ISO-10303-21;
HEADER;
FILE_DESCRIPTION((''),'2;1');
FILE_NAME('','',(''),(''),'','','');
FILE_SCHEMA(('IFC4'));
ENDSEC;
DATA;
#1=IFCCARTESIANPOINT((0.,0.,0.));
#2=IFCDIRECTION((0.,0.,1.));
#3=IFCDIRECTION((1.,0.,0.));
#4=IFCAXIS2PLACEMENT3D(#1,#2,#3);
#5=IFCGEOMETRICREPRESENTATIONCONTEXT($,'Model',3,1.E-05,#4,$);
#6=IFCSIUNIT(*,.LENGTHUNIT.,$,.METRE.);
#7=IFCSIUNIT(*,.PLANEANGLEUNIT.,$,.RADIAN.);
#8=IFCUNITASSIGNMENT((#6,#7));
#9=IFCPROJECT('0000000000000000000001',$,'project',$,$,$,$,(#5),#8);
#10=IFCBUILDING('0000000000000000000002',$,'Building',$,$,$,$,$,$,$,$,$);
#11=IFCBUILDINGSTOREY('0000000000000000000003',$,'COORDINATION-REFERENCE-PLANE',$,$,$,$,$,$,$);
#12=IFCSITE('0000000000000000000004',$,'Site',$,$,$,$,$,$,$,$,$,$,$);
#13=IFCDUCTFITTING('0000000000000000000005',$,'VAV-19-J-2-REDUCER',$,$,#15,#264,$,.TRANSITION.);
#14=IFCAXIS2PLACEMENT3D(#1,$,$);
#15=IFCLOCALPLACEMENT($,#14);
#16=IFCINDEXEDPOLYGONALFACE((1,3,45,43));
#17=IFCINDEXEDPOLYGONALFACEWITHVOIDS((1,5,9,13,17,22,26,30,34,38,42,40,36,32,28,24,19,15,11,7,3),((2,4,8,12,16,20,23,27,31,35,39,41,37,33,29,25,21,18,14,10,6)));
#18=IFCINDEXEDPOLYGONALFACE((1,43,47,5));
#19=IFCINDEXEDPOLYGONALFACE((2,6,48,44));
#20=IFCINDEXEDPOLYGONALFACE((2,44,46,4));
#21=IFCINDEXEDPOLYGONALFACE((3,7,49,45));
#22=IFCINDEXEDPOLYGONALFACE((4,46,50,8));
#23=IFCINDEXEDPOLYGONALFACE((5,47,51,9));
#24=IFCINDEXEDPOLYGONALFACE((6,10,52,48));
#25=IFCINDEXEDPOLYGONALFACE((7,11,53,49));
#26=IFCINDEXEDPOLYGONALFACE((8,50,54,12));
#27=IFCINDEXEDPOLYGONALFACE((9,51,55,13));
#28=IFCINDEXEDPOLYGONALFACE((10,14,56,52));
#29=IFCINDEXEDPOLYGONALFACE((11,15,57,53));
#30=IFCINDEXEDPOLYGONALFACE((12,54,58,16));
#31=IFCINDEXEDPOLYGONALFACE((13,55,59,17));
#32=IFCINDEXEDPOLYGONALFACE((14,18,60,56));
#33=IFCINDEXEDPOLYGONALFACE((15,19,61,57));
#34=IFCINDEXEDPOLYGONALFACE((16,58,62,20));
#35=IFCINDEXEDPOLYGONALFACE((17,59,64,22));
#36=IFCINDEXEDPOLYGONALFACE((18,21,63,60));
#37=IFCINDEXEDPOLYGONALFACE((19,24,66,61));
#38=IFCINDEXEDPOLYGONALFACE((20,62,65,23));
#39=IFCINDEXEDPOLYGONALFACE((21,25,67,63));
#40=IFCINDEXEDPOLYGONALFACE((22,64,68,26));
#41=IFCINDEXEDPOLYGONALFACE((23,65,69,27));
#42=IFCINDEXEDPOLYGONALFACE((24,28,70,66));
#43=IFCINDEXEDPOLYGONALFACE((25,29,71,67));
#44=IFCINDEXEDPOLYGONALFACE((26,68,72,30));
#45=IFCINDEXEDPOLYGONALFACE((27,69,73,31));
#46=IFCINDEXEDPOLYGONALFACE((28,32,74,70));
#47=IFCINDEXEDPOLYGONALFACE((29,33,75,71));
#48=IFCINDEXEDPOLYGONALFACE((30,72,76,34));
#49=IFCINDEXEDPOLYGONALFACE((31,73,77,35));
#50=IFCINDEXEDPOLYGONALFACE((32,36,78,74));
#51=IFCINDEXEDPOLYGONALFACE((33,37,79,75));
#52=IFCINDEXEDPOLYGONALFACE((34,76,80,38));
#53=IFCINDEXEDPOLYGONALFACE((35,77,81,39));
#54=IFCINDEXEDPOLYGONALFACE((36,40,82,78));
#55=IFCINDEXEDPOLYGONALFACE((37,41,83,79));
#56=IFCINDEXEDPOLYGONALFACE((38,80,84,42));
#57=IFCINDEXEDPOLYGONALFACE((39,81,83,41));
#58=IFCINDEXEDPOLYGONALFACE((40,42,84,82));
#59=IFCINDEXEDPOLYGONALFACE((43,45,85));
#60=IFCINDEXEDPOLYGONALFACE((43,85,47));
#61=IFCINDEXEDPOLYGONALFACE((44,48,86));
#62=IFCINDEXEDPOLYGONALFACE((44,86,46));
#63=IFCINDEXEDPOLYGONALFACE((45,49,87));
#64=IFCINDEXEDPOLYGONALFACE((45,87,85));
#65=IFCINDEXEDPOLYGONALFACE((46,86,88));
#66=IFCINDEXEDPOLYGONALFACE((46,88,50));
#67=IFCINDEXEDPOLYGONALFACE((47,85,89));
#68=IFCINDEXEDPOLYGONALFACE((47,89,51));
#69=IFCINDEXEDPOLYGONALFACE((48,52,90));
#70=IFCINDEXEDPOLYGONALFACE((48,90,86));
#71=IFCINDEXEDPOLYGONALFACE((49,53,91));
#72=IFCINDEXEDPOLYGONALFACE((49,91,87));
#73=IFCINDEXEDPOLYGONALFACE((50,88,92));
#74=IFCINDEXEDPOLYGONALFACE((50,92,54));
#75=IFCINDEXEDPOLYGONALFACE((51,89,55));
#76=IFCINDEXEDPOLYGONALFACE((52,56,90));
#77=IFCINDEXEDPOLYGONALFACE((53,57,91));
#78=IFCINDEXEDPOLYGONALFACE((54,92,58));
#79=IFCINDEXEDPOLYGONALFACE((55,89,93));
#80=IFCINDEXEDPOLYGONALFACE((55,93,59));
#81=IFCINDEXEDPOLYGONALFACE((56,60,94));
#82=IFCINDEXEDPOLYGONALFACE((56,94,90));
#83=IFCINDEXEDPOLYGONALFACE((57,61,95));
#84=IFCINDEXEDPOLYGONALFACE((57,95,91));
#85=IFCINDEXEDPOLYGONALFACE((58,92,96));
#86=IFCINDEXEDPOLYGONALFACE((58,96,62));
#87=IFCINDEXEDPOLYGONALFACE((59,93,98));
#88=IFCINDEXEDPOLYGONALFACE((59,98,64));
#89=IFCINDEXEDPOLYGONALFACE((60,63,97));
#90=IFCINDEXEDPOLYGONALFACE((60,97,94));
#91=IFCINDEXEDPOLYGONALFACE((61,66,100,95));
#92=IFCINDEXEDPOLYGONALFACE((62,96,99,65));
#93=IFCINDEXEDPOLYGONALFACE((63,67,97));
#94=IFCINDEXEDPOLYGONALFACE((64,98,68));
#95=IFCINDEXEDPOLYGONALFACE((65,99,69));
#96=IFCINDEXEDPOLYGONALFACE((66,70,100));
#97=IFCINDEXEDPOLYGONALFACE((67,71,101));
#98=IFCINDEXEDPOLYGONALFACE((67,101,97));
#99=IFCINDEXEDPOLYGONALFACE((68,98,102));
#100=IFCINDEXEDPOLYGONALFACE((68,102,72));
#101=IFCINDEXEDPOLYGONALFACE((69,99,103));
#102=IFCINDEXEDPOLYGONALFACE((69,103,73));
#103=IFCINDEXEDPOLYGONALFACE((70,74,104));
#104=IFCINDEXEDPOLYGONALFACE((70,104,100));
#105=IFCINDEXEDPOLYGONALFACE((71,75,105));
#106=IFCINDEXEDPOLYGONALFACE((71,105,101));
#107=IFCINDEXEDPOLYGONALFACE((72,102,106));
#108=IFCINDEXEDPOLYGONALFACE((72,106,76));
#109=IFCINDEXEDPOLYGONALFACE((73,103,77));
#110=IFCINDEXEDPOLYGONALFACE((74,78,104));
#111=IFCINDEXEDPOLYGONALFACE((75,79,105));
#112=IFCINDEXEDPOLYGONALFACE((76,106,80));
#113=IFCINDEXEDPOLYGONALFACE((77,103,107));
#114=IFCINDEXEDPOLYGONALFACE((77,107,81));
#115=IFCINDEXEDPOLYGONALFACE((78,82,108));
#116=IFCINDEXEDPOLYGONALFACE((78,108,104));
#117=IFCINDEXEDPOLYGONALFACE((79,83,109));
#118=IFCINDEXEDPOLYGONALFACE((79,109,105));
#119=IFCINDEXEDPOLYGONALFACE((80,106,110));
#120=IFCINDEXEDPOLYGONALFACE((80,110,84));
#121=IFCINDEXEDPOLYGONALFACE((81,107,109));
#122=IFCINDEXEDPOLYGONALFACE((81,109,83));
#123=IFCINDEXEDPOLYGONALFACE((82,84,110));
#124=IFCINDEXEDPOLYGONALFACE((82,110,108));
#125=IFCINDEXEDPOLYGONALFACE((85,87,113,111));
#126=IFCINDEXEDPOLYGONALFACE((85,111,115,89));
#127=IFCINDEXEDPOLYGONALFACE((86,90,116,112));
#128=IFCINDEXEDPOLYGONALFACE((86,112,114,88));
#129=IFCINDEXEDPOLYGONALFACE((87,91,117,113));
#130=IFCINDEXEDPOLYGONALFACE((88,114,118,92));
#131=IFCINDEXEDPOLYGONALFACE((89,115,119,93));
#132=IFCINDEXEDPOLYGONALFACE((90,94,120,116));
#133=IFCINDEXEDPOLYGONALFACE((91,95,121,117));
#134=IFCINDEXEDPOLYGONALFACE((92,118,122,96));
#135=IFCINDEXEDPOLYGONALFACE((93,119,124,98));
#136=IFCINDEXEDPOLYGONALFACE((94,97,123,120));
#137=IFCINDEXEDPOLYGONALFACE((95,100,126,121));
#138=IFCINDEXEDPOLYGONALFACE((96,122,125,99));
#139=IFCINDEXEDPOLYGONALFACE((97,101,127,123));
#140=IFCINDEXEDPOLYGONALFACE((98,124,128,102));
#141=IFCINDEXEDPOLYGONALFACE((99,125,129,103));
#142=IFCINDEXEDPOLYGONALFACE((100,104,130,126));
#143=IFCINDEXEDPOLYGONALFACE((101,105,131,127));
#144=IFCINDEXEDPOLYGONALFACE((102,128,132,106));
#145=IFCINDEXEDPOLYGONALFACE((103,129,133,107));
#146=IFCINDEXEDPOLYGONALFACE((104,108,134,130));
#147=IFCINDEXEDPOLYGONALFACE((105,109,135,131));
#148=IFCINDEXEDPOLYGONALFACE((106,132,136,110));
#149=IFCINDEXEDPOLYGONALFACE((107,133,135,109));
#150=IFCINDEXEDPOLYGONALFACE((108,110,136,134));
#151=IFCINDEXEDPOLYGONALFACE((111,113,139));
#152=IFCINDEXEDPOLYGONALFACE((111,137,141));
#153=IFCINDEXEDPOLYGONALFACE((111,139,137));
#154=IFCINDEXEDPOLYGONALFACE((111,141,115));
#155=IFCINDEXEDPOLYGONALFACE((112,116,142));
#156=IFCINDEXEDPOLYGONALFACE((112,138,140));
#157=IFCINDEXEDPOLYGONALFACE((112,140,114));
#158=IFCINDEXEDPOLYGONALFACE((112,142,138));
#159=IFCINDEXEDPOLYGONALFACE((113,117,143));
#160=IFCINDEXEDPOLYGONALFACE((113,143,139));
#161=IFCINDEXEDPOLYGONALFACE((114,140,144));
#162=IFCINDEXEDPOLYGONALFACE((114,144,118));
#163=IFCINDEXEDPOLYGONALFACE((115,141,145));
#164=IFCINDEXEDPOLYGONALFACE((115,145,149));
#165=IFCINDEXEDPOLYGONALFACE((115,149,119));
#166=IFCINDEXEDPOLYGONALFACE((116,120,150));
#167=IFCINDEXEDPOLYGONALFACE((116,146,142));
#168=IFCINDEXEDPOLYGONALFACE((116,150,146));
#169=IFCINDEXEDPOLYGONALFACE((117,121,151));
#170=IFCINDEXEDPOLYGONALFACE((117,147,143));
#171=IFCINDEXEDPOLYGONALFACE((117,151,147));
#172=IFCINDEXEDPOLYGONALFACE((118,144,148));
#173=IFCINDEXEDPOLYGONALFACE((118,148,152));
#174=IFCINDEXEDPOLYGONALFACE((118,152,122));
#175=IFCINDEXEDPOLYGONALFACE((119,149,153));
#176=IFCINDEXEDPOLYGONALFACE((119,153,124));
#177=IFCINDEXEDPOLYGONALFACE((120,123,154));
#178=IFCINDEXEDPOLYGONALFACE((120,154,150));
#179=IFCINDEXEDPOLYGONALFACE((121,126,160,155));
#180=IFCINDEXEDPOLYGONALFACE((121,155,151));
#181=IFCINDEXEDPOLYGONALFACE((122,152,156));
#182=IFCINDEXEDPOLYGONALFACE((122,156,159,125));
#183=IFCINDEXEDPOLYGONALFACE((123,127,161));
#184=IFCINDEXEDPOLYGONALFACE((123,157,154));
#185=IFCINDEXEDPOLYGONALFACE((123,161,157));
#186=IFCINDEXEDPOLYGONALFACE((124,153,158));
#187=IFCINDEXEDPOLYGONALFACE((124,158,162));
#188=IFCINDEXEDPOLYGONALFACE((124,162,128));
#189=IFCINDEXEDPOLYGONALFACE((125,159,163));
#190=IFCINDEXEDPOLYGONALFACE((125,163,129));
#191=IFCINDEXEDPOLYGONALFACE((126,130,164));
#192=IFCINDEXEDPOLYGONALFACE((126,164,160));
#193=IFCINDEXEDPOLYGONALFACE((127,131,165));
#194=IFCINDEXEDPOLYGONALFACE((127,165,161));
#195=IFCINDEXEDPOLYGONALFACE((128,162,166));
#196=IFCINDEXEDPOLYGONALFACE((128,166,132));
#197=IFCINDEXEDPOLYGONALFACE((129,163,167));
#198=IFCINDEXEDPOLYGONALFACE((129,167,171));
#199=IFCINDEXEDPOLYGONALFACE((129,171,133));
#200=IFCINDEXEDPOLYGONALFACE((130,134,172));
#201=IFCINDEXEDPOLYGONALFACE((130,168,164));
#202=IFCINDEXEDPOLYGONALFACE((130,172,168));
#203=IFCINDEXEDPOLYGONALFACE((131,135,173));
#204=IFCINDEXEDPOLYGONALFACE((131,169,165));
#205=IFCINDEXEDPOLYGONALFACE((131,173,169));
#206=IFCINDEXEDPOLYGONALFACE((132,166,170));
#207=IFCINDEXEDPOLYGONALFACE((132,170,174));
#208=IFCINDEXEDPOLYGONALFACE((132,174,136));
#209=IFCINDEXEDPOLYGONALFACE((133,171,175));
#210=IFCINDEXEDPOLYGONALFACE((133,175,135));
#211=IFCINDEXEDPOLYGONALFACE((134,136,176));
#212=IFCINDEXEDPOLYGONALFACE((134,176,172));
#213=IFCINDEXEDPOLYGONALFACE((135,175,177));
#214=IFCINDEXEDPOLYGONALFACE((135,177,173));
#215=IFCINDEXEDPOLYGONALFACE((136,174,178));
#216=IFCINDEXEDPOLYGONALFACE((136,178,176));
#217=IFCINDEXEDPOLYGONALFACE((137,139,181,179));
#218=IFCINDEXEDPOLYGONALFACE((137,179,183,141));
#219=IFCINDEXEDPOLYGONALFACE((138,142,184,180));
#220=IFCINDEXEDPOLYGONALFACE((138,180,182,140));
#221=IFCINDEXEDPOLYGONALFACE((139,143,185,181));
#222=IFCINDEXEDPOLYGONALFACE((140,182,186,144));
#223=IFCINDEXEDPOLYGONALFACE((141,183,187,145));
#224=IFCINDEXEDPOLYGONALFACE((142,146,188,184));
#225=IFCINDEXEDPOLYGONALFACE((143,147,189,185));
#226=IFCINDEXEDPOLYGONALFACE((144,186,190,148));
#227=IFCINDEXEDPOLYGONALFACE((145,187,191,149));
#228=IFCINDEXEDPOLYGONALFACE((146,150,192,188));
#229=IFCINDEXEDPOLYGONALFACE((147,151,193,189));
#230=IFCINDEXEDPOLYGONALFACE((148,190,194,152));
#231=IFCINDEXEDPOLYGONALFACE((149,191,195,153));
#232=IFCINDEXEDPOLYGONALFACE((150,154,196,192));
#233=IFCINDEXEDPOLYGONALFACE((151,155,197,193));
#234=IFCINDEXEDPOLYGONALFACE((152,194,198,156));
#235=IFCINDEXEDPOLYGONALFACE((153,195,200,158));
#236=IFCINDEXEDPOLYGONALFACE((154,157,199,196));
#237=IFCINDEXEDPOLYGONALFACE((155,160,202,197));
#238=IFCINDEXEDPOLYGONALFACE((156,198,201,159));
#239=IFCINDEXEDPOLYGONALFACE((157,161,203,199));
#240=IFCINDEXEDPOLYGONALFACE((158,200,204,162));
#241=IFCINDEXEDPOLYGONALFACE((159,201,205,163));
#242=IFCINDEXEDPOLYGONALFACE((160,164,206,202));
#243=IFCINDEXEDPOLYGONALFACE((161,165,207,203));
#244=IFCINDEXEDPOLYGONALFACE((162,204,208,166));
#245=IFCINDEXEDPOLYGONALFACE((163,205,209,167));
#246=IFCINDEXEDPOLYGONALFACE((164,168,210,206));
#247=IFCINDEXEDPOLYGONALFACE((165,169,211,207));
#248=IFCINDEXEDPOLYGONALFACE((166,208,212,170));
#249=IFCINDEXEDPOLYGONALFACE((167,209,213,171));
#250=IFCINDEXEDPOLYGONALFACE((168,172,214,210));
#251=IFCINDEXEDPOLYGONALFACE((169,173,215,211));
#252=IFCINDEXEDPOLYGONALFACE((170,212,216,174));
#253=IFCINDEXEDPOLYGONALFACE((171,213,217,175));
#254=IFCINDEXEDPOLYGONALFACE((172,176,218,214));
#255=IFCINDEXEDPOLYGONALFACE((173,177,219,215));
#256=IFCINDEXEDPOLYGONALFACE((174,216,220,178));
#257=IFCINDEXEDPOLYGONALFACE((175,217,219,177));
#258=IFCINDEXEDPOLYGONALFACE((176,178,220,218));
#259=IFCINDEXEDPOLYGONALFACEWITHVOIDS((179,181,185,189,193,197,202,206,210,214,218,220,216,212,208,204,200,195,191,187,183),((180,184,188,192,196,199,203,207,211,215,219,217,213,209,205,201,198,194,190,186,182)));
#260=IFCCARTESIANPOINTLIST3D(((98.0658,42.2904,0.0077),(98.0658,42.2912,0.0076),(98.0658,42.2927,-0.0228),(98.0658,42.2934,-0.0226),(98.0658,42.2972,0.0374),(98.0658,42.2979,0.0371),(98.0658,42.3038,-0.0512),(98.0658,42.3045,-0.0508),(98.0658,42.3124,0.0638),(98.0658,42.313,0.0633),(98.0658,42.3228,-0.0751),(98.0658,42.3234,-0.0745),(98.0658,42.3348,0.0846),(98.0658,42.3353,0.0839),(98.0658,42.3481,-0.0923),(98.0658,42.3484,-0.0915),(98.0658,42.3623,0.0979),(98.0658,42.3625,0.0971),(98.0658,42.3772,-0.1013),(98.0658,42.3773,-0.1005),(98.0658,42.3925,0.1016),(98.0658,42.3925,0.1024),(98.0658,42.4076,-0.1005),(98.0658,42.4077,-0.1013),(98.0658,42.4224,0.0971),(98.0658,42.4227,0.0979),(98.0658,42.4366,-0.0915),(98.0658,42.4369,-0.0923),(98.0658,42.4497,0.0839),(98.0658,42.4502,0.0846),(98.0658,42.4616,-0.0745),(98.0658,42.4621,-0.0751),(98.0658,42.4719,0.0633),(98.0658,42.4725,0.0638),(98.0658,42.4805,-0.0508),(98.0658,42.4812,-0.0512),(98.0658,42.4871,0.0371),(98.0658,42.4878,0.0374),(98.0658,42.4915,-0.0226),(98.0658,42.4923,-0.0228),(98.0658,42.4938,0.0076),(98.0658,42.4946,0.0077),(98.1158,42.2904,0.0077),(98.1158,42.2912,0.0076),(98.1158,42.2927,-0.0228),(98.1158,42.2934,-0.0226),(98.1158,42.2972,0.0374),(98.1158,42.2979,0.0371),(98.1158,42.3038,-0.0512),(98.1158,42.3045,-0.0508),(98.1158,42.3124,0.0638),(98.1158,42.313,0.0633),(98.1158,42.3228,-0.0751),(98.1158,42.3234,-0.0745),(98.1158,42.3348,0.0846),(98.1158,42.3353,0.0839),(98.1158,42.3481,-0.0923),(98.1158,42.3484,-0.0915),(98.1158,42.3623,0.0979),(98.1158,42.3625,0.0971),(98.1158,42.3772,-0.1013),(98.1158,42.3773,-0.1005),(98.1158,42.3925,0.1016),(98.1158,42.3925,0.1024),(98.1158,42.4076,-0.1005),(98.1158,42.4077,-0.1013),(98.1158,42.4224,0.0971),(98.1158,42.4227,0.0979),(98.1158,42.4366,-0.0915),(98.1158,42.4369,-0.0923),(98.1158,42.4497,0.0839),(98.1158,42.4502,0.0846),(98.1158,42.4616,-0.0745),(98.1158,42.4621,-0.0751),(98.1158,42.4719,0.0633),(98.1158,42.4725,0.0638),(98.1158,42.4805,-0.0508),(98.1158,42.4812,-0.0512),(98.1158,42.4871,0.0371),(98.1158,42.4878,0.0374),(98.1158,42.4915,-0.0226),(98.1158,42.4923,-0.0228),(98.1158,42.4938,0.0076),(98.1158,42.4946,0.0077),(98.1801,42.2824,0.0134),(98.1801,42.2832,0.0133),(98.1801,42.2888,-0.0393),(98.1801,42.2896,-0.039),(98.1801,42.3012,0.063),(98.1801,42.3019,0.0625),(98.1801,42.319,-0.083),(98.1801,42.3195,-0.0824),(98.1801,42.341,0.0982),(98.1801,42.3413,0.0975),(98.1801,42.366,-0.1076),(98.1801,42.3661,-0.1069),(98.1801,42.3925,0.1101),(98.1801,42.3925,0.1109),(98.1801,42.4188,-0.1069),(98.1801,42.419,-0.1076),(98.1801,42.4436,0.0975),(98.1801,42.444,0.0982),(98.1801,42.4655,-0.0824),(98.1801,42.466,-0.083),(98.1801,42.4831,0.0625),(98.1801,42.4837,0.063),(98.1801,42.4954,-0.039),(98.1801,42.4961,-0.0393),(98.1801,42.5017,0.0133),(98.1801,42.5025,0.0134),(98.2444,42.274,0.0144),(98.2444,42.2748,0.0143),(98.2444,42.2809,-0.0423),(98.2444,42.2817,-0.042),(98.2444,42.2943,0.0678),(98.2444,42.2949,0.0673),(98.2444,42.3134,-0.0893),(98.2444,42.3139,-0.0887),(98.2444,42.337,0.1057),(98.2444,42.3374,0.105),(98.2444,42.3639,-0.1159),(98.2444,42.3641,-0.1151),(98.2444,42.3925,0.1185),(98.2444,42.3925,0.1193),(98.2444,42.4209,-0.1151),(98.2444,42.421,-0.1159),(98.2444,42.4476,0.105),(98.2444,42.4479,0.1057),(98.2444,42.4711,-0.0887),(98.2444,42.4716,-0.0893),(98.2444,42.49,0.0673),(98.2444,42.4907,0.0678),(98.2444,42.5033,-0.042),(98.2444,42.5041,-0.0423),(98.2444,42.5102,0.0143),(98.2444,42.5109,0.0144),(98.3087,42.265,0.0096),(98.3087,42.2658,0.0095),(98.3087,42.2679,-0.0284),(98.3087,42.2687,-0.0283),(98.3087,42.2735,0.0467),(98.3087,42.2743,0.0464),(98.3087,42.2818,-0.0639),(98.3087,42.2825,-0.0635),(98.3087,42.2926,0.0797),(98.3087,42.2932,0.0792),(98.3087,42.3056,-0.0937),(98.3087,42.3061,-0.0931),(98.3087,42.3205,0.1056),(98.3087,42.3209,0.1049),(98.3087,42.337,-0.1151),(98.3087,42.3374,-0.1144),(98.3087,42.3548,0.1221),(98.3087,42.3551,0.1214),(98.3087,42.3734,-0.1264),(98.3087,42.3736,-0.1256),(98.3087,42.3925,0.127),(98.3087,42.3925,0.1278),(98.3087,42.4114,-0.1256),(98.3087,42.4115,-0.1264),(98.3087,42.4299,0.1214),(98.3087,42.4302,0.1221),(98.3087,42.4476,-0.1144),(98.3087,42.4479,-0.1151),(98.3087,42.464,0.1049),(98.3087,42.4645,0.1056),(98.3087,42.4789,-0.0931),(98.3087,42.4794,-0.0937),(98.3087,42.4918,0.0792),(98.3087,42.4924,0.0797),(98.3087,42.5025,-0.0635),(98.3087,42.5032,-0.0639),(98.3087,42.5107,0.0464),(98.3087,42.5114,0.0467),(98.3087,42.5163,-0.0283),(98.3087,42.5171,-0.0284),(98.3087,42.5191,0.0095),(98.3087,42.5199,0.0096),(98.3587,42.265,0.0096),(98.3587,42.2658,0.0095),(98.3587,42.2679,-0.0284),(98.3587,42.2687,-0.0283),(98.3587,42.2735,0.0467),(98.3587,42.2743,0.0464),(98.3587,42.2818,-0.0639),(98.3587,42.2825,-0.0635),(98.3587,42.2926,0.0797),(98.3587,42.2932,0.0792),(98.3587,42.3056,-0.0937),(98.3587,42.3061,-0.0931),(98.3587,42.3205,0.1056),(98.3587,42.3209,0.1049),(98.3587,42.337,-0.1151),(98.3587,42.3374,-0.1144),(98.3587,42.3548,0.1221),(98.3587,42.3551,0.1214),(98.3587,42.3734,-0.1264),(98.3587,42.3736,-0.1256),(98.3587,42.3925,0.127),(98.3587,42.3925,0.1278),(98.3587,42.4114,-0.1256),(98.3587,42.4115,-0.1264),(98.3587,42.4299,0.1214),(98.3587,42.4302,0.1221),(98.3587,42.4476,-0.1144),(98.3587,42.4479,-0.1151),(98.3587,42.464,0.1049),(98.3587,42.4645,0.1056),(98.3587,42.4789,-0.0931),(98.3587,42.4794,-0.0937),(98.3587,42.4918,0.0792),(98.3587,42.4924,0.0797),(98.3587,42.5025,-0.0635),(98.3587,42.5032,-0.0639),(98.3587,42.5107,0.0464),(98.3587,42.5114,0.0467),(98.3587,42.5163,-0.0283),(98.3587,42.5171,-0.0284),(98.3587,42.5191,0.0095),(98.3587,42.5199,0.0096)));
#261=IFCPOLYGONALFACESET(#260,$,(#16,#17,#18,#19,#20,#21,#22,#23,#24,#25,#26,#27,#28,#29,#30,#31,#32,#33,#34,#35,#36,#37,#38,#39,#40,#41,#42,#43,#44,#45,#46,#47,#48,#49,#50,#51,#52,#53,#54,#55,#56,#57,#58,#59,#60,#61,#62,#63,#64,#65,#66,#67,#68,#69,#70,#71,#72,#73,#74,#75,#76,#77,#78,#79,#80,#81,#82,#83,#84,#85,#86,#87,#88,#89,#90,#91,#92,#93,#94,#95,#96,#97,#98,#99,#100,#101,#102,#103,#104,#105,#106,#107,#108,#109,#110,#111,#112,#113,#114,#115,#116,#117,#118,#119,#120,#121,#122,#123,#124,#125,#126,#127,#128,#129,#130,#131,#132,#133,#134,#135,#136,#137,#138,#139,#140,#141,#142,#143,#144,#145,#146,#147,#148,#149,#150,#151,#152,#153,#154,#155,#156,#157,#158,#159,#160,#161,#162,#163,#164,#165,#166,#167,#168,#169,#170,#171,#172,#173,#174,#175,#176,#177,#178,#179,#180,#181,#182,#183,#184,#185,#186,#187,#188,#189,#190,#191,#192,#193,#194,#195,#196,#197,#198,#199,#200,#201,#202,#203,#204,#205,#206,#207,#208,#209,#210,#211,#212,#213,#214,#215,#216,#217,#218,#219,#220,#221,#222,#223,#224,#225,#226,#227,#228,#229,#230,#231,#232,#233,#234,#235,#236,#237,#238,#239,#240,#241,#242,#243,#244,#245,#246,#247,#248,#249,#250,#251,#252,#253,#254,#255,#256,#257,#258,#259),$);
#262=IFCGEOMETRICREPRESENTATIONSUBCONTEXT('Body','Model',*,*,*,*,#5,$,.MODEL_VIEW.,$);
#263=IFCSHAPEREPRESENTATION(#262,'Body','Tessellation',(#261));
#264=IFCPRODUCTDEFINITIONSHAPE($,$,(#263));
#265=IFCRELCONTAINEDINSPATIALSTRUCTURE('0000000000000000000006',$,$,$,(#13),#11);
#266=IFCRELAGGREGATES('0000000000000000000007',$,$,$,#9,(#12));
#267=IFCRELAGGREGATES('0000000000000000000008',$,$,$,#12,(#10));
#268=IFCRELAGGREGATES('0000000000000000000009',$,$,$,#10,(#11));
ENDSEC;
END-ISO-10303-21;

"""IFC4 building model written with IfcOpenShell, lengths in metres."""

from ifc_helpers import new_model, entity, si_unit, frame, origin_with_axes, place, context, subcontext, project, spatial, element, save


model = new_model("IFC4")

# Units and contexts
model_context = context("Model", 3, precision=1e-05, world=origin_with_axes())
body_context_1 = subcontext(model_context, "Body", "Model", "MODEL_VIEW")
ifc_project = project(units=[si_unit("LENGTHUNIT", "METRE"), si_unit("PLANEANGLEUNIT", "RADIAN")], contexts=[model_context])

# Site, building, storey
site = spatial("IfcSite", under=ifc_project, Name="Site")
building = spatial("IfcBuilding", under=site, Name="Building")
storey = spatial("IfcBuildingStorey", under=building, Name="COORDINATION-REFERENCE-PLANE")

# Duct fitting
for number, where, z_axis, x_axis, name in (
    (1, (98.3587, 42.3925, 0.0), (0.0, -1.0, 0.0), (0.0, 0.0, 1.0), "VAV-19-J-2-REDUCER"),
):
    element("IfcDuctFitting", number, at=place(None, frame(where, z_axis=z_axis, x_axis=x_axis)), inside=storey, Name=name, PredefinedType="TRANSITION", context=body_context_1, shape_type="SweptSolid", body=[
        entity("IfcRevolvedAreaSolid", entity("IfcArbitraryClosedProfileDef", "AREA", None, entity("IfcPolyline", [entity("IfcCartesianPoint", [0.1278, 0.0]), entity("IfcCartesianPoint", [0.1278, 0.05]), entity("IfcCartesianPoint", [0.1024, 0.2429]), entity("IfcCartesianPoint", [0.1024, 0.2929]), entity("IfcCartesianPoint", [0.1016, 0.2929]), entity("IfcCartesianPoint", [0.1016, 0.2429]), entity("IfcCartesianPoint", [0.127, 0.05]), entity("IfcCartesianPoint", [0.127, 0.0]), entity("IfcCartesianPoint", [0.1278, 0.0])])), entity("IfcAxis2Placement3D", entity("IfcCartesianPoint", [0.0, 0.0, 0.0])), entity("IfcAxis1Placement", entity("IfcCartesianPoint", [0.0, 0.0, 0.0]), entity("IfcDirection", [0.0, 1.0, 0.0])), 6.283185),
    ])

save(model, "model.ifc")
